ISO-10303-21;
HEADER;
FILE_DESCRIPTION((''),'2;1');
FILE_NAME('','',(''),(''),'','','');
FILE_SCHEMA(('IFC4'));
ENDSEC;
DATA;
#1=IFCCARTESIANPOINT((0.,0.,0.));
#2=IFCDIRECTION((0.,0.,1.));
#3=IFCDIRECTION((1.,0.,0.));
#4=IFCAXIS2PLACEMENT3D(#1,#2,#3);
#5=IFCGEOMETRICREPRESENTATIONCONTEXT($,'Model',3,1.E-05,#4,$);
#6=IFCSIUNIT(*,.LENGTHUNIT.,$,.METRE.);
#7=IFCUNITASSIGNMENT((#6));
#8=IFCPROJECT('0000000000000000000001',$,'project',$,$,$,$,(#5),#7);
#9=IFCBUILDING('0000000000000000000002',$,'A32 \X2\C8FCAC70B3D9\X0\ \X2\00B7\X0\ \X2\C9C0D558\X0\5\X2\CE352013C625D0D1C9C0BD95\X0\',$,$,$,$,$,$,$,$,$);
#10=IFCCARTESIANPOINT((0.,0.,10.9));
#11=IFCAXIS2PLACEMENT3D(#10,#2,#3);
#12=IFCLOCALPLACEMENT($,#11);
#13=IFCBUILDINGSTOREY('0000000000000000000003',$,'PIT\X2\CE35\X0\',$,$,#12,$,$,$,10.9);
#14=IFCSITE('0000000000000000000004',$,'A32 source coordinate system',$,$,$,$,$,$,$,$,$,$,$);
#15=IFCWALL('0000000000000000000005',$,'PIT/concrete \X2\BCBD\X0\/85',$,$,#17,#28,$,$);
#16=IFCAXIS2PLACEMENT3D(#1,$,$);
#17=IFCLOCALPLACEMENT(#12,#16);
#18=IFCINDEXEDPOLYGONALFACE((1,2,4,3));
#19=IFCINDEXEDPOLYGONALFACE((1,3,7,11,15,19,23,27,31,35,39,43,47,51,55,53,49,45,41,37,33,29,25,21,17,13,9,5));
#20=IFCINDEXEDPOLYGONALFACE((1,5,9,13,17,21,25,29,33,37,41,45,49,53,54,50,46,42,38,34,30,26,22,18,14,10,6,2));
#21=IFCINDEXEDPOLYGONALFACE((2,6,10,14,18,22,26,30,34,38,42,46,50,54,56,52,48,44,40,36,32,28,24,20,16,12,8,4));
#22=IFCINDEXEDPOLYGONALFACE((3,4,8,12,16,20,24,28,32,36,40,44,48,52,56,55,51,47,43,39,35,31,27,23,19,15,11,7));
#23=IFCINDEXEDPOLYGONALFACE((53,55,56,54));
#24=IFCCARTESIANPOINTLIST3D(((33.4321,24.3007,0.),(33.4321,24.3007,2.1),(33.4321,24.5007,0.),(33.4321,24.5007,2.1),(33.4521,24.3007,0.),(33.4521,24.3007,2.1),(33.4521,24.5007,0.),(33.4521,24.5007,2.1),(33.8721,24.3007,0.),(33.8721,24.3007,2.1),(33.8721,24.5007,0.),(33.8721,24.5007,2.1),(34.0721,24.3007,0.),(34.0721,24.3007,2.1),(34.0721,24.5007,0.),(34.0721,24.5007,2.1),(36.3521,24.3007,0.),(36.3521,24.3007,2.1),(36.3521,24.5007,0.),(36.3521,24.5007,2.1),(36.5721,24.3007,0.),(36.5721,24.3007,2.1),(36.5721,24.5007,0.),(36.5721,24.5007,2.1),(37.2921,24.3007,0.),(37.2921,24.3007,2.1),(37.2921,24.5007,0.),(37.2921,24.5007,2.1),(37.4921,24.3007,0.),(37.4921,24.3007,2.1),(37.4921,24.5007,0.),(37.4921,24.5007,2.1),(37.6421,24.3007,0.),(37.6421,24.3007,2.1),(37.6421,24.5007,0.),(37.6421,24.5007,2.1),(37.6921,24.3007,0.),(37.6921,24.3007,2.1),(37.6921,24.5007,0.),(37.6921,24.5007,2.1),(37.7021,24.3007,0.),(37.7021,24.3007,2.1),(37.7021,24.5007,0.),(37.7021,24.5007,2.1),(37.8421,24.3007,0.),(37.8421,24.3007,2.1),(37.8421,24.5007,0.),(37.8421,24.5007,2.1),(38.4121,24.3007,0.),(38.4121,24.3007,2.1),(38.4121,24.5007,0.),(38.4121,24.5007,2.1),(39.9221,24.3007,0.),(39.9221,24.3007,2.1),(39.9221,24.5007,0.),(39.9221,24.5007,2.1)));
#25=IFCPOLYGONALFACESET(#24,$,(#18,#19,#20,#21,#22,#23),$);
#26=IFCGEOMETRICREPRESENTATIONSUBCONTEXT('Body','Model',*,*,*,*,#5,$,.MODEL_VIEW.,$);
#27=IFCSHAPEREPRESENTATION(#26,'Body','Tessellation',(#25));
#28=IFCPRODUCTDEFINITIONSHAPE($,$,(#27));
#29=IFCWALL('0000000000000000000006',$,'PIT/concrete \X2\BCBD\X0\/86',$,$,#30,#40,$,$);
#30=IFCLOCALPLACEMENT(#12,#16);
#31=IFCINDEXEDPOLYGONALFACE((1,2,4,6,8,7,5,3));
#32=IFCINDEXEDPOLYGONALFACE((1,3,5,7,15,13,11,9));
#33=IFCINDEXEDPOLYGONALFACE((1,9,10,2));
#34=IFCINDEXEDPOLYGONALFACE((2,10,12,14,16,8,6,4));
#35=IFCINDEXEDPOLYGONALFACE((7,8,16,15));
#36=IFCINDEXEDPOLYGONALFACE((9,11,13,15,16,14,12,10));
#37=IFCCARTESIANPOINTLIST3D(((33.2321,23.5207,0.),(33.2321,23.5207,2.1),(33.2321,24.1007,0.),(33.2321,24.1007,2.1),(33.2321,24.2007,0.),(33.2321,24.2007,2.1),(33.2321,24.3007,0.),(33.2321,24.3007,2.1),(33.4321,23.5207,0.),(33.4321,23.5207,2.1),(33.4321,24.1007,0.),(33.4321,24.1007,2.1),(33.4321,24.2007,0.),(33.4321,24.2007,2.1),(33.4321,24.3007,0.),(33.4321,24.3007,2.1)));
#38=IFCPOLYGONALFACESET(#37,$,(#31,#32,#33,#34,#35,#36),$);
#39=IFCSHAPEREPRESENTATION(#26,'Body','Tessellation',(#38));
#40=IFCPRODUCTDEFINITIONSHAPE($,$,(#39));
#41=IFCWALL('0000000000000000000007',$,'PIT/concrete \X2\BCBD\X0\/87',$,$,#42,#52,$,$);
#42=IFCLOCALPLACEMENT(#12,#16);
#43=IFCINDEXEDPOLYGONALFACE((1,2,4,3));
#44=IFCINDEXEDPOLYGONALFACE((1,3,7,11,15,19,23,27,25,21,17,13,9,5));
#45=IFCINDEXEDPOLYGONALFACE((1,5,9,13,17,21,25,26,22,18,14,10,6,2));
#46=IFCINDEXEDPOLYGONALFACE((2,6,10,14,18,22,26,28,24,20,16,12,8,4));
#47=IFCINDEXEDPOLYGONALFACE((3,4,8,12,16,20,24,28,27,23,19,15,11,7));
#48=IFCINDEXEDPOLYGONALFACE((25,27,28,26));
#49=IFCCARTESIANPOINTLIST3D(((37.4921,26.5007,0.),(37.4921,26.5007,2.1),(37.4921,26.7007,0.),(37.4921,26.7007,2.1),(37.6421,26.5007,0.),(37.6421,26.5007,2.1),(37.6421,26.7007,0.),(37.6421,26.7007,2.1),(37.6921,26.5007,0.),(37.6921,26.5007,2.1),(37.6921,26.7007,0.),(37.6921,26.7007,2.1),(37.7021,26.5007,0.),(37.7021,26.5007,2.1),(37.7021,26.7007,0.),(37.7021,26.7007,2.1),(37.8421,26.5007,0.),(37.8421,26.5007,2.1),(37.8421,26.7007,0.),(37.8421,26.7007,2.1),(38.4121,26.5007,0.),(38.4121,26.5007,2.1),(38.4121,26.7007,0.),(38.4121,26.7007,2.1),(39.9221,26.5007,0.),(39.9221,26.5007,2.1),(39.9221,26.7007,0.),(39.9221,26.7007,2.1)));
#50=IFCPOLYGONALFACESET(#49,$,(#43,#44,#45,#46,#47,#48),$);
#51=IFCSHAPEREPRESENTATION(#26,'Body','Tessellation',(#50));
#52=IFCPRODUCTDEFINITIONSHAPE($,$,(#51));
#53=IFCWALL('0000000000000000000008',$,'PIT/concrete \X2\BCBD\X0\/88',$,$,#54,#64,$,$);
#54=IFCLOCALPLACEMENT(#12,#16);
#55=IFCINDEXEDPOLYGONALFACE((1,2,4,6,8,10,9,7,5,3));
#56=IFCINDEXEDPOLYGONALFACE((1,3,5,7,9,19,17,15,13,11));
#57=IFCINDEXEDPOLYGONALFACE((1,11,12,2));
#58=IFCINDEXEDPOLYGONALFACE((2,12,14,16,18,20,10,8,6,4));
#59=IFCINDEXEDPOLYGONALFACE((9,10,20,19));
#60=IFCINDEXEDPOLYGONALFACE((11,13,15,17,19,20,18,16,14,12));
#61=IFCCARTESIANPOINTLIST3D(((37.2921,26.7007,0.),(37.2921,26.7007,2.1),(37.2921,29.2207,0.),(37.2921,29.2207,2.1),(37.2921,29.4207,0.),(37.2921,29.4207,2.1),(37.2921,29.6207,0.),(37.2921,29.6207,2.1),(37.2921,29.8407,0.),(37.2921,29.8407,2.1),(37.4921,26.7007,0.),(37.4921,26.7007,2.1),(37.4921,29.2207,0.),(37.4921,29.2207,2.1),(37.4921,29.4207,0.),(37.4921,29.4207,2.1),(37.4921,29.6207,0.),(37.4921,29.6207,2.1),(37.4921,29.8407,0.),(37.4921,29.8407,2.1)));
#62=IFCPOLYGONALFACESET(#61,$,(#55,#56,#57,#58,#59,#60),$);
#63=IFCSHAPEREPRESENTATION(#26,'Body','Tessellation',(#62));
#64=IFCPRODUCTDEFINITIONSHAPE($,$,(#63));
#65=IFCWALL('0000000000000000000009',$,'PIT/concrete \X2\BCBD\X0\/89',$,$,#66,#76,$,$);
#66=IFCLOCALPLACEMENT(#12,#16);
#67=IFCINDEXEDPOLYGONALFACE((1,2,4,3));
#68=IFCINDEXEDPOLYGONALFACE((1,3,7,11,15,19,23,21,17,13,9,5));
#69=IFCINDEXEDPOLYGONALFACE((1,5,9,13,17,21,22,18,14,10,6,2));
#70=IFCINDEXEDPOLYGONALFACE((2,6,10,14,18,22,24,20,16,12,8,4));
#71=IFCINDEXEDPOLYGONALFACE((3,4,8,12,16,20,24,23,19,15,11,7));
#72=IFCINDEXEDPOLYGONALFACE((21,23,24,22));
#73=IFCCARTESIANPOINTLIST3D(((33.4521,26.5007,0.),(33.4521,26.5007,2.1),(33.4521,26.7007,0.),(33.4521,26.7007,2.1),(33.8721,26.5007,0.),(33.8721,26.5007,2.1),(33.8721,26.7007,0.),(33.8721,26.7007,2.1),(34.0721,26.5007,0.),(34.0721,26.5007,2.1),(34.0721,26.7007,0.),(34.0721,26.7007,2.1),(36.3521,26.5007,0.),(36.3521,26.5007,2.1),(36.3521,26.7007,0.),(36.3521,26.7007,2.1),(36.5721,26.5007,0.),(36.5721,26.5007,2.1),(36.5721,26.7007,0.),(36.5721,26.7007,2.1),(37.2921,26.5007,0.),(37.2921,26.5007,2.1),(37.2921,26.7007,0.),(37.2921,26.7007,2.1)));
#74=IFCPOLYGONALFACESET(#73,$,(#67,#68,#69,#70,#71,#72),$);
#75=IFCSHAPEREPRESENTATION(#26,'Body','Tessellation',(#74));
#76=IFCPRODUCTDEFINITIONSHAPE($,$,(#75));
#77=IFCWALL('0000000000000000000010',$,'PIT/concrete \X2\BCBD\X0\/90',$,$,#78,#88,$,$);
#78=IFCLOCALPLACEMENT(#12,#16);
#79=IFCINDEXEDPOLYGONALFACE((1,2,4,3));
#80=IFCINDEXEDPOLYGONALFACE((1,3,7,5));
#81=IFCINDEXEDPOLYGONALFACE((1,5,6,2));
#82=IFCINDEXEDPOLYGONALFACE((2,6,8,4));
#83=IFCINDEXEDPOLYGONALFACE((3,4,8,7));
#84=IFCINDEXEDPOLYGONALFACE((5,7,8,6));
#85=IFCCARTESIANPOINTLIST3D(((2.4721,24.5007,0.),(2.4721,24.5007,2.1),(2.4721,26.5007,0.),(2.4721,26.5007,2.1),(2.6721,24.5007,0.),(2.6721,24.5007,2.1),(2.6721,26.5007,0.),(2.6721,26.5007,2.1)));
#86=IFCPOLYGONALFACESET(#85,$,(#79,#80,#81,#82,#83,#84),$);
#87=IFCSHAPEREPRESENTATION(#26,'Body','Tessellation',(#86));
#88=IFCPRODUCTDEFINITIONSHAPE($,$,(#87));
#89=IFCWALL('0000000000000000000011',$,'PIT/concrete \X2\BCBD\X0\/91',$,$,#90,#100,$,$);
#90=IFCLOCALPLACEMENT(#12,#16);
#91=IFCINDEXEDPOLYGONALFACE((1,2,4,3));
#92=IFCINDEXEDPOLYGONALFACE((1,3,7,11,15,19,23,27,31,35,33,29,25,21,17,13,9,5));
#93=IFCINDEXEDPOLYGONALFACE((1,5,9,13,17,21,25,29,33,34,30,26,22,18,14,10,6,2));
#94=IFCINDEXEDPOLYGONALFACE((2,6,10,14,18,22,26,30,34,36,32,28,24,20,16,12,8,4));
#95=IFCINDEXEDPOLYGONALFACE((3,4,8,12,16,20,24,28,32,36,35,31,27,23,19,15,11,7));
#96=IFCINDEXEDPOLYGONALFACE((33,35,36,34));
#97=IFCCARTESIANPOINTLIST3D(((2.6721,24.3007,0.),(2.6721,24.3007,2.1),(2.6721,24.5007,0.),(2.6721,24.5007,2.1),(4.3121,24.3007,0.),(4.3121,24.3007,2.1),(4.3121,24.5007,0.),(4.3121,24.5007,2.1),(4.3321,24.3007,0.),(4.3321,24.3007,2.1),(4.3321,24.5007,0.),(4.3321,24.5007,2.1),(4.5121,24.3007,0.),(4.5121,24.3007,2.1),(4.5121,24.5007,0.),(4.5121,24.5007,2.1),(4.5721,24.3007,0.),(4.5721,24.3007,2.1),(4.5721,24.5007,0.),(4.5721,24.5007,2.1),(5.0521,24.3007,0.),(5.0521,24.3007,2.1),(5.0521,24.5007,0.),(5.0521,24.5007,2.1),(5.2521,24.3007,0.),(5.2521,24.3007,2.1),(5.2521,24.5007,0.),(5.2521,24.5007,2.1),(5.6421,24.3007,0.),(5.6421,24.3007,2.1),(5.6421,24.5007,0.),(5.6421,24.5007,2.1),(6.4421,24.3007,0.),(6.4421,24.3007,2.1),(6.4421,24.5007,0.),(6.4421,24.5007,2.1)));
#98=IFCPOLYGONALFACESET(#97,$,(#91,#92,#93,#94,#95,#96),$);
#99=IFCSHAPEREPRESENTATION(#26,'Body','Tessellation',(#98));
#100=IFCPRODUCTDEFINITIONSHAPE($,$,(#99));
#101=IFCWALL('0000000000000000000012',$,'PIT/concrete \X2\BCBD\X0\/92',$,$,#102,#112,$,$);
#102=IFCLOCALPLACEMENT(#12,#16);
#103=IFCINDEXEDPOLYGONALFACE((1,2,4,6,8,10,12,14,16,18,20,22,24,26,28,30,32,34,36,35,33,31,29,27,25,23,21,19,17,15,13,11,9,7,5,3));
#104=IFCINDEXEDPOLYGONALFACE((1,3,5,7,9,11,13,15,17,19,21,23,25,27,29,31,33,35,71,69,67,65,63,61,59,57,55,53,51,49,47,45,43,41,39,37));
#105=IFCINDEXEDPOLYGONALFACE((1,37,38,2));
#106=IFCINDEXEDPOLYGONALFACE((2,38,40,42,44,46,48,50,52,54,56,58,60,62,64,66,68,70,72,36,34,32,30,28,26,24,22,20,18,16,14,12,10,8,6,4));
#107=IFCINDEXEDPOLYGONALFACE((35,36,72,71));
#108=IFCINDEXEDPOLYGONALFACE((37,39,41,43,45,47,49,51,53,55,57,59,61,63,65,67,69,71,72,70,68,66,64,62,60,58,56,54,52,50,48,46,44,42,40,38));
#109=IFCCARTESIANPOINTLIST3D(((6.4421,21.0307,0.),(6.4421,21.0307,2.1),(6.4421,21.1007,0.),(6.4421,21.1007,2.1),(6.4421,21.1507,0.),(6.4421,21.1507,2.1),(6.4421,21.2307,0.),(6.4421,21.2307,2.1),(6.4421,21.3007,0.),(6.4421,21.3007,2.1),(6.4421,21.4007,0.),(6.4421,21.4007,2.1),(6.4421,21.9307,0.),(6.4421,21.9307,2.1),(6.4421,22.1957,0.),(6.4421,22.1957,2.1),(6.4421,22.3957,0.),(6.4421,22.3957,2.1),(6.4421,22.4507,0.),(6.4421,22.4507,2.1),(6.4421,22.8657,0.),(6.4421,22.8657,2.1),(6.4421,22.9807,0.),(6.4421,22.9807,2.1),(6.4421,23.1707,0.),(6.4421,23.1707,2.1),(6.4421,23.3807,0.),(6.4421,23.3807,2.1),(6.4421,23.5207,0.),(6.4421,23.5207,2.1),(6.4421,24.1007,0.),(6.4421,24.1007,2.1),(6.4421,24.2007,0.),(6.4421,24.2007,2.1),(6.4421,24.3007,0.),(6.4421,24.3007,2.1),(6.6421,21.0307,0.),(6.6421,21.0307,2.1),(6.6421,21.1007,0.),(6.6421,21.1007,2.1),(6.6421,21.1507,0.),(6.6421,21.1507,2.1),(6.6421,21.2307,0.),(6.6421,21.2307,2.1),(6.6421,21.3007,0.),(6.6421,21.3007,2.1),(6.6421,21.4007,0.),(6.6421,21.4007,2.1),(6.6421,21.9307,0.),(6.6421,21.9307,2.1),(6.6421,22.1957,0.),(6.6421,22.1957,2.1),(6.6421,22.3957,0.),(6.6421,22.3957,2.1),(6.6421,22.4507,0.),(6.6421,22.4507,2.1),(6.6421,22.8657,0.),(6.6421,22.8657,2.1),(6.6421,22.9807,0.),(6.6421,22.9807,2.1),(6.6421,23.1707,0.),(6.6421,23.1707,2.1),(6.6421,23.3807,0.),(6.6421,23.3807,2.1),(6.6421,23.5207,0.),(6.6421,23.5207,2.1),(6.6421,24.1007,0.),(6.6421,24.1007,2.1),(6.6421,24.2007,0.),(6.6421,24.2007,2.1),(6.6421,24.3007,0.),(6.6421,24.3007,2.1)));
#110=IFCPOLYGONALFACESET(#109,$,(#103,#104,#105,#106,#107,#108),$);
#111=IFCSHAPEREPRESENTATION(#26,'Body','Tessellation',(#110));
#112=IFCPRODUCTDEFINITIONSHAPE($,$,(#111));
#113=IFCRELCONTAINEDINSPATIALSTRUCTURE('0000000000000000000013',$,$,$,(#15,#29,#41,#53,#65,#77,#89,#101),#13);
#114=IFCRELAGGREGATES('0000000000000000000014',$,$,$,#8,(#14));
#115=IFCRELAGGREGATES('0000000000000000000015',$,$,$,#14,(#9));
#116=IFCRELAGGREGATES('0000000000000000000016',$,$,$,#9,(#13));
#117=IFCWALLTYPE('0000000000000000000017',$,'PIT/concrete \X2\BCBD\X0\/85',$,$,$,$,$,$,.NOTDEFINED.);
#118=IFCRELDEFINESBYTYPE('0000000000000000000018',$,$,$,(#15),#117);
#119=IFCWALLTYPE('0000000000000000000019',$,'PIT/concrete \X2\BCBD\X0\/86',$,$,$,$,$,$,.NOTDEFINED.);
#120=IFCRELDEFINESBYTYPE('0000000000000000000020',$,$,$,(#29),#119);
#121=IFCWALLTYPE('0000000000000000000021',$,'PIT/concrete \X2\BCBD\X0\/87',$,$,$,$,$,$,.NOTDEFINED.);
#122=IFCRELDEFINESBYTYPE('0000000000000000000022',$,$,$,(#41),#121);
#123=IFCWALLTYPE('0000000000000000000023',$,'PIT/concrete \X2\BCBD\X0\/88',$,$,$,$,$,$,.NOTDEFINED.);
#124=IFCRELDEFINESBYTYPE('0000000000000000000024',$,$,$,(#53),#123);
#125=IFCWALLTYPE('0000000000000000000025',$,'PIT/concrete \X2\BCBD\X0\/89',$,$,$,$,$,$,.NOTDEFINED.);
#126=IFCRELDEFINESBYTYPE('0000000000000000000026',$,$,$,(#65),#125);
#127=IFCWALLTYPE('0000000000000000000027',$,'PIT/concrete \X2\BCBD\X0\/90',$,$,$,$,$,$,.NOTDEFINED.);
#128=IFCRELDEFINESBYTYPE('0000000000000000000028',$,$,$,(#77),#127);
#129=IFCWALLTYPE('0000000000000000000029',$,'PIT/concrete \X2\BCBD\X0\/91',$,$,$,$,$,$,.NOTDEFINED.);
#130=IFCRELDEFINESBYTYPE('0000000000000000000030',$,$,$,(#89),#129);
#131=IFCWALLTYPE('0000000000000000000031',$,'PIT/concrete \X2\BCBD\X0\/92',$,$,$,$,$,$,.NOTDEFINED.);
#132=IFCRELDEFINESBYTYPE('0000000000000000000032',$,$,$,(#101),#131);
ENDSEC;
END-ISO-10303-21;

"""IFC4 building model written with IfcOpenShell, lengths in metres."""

from ifc_helpers import new_model, si_unit, frame, origin, origin_with_axes, place, context, subcontext, project, spatial, polyline, outline, extrude, source, transform, mapped, type_object, type_shapes, element, save


model = new_model("IFC4")

# Units and contexts
model_context = context("Model", 3, precision=1e-05, world=origin_with_axes())
body_context = subcontext(model_context, "Body", "Model", "MODEL_VIEW")
ifc_project = project(units=[si_unit("LENGTHUNIT", "METRE")], contexts=[model_context])

# Site, building, storey
site = spatial("IfcSite", under=ifc_project, Name="A32 source coordinate system")
building = spatial("IfcBuilding", under=site, Name="A32 주거동 · 지하5층–옥탑지붕")
storey_placement = place(None, frame((0.0, 0.0, 10.9), z_axis=(0.0, 0.0, 1.0), x_axis=(1.0, 0.0, 0.0)))
storey = spatial("IfcBuildingStorey", under=building, at=storey_placement, Name="PIT층", Elevation=10.9)

# Walls
wall_type_1 = type_object("IfcWallType", Name="PIT/concrete 벽/85", PredefinedType="NOTDEFINED")
shared_shape_1 = source(origin(), body_context, "Body", "SweptSolid", [
    extrude(outline(polyline([(37.8421, 24.3007), (37.7021, 24.3007), (37.6921, 24.3007), (37.6421, 24.3007), (37.4921, 24.3007), (37.2921, 24.3007), (36.5721, 24.3007), (36.3521, 24.3007), (34.0721, 24.3007), (33.8721, 24.3007), (33.4521, 24.3007), (33.4321, 24.3007), (33.4321, 24.5007), (33.4521, 24.5007), (33.8721, 24.5007), (34.0721, 24.5007), (36.3521, 24.5007), (36.5721, 24.5007), (37.2921, 24.5007), (37.4921, 24.5007), (37.6421, 24.5007), (37.6921, 24.5007), (37.7021, 24.5007), (37.8421, 24.5007), (38.4121, 24.5007), (39.9221, 24.5007), (39.9221, 24.3007), (38.4121, 24.3007), (37.8421, 24.3007)])), origin(), (0.0, 0.0, 1.0), 2.1),
])
type_shapes(wall_type_1, [shared_shape_1])
wall_1_placement = place(storey_placement, origin_with_axes())
element("IfcWall", 1, at=wall_1_placement, inside=storey, type_object=wall_type_1, Name="PIT/concrete 벽/85", context=body_context, shape_type="MappedRepresentation", body=[
    mapped(shared_shape_1, transform((0.0, 0.0, 0.0), scale=1.0)),
])
wall_type_2 = type_object("IfcWallType", Name="PIT/concrete 벽/86", PredefinedType="NOTDEFINED")
shared_shape_2 = source(origin(), body_context, "Body", "SweptSolid", [
    extrude(outline(polyline([(33.4321, 23.5207), (33.2321, 23.5207), (33.2321, 24.1007), (33.2321, 24.2007), (33.2321, 24.3007), (33.4321, 24.3007), (33.4321, 24.2007), (33.4321, 24.1007), (33.4321, 23.5207)])), origin(), (0.0, 0.0, 1.0), 2.1),
])
type_shapes(wall_type_2, [shared_shape_2])
wall_2_placement = place(storey_placement, origin_with_axes())
element("IfcWall", 2, at=wall_2_placement, inside=storey, type_object=wall_type_2, Name="PIT/concrete 벽/86", context=body_context, shape_type="MappedRepresentation", body=[
    mapped(shared_shape_2, transform((0.0, 0.0, 0.0), scale=1.0)),
])
wall_type_3 = type_object("IfcWallType", Name="PIT/concrete 벽/87", PredefinedType="NOTDEFINED")
shared_shape_3 = source(origin(), body_context, "Body", "SweptSolid", [
    extrude(outline(polyline([(37.7021, 26.5007), (37.6921, 26.5007), (37.6421, 26.5007), (37.4921, 26.5007), (37.4921, 26.7007), (37.6421, 26.7007), (37.6921, 26.7007), (37.7021, 26.7007), (37.8421, 26.7007), (38.4121, 26.7007), (39.9221, 26.7007), (39.9221, 26.5007), (38.4121, 26.5007), (37.8421, 26.5007), (37.7021, 26.5007)])), origin(), (0.0, 0.0, 1.0), 2.1),
])
type_shapes(wall_type_3, [shared_shape_3])
wall_3_placement = place(storey_placement, origin_with_axes())
element("IfcWall", 3, at=wall_3_placement, inside=storey, type_object=wall_type_3, Name="PIT/concrete 벽/87", context=body_context, shape_type="MappedRepresentation", body=[
    mapped(shared_shape_3, transform((0.0, 0.0, 0.0), scale=1.0)),
])
wall_type_4 = type_object("IfcWallType", Name="PIT/concrete 벽/88", PredefinedType="NOTDEFINED")
shared_shape_4 = source(origin(), body_context, "Body", "SweptSolid", [
    extrude(outline(polyline([(37.2921, 29.4207), (37.2921, 29.6207), (37.2921, 29.8407), (37.4921, 29.8407), (37.4921, 29.6207), (37.4921, 29.4207), (37.4921, 29.2207), (37.4921, 26.7007), (37.2921, 26.7007), (37.2921, 29.2207), (37.2921, 29.4207)])), origin(), (0.0, 0.0, 1.0), 2.1),
])
type_shapes(wall_type_4, [shared_shape_4])
wall_4_placement = place(storey_placement, origin_with_axes())
element("IfcWall", 4, at=wall_4_placement, inside=storey, type_object=wall_type_4, Name="PIT/concrete 벽/88", context=body_context, shape_type="MappedRepresentation", body=[
    mapped(shared_shape_4, transform((0.0, 0.0, 0.0), scale=1.0)),
])
wall_type_5 = type_object("IfcWallType", Name="PIT/concrete 벽/89", PredefinedType="NOTDEFINED")
shared_shape_5 = source(origin(), body_context, "Body", "SweptSolid", [
    extrude(outline(polyline([(36.3521, 26.5007), (34.0721, 26.5007), (33.8721, 26.5007), (33.4521, 26.5007), (33.4521, 26.7007), (33.8721, 26.7007), (34.0721, 26.7007), (36.3521, 26.7007), (36.5721, 26.7007), (37.2921, 26.7007), (37.2921, 26.5007), (36.5721, 26.5007), (36.3521, 26.5007)])), origin(), (0.0, 0.0, 1.0), 2.1),
])
type_shapes(wall_type_5, [shared_shape_5])
wall_5_placement = place(storey_placement, origin_with_axes())
element("IfcWall", 5, at=wall_5_placement, inside=storey, type_object=wall_type_5, Name="PIT/concrete 벽/89", context=body_context, shape_type="MappedRepresentation", body=[
    mapped(shared_shape_5, transform((0.0, 0.0, 0.0), scale=1.0)),
])
wall_type_6 = type_object("IfcWallType", Name="PIT/concrete 벽/90", PredefinedType="NOTDEFINED")
shared_shape_6 = source(origin(), body_context, "Body", "SweptSolid", [
    extrude(outline(polyline([(2.4721, 24.5007), (2.4721, 26.5007), (2.6721, 26.5007), (2.6721, 24.5007), (2.4721, 24.5007)])), origin(), (0.0, 0.0, 1.0), 2.1),
])
type_shapes(wall_type_6, [shared_shape_6])
wall_6_placement = place(storey_placement, origin_with_axes())
element("IfcWall", 6, at=wall_6_placement, inside=storey, type_object=wall_type_6, Name="PIT/concrete 벽/90", context=body_context, shape_type="MappedRepresentation", body=[
    mapped(shared_shape_6, transform((0.0, 0.0, 0.0), scale=1.0)),
])
wall_type_7 = type_object("IfcWallType", Name="PIT/concrete 벽/91", PredefinedType="NOTDEFINED")
shared_shape_7 = source(origin(), body_context, "Body", "SweptSolid", [
    extrude(outline(polyline([(4.5121, 24.5007), (4.5721, 24.5007), (5.0521, 24.5007), (5.2521, 24.5007), (5.6421, 24.5007), (6.4421, 24.5007), (6.4421, 24.3007), (5.6421, 24.3007), (5.2521, 24.3007), (5.0521, 24.3007), (4.5721, 24.3007), (4.5121, 24.3007), (4.3321, 24.3007), (4.3121, 24.3007), (2.6721, 24.3007), (2.6721, 24.5007), (4.3121, 24.5007), (4.3321, 24.5007), (4.5121, 24.5007)])), origin(), (0.0, 0.0, 1.0), 2.1),
])
type_shapes(wall_type_7, [shared_shape_7])
wall_7_placement = place(storey_placement, origin_with_axes())
element("IfcWall", 7, at=wall_7_placement, inside=storey, type_object=wall_type_7, Name="PIT/concrete 벽/91", context=body_context, shape_type="MappedRepresentation", body=[
    mapped(shared_shape_7, transform((0.0, 0.0, 0.0), scale=1.0)),
])
wall_type_8 = type_object("IfcWallType", Name="PIT/concrete 벽/92", PredefinedType="NOTDEFINED")
shared_shape_8 = source(origin(), body_context, "Body", "SweptSolid", [
    extrude(outline(polyline([(6.6421, 24.1007), (6.6421, 23.5207), (6.6421, 23.3807), (6.6421, 23.1707), (6.6421, 22.9807), (6.6421, 22.8657), (6.6421, 22.4507), (6.6421, 22.3957), (6.6421, 22.1957), (6.6421, 21.9307), (6.6421, 21.4007), (6.6421, 21.3007), (6.6421, 21.2307), (6.6421, 21.1507), (6.6421, 21.1007), (6.6421, 21.0307), (6.4421, 21.0307), (6.4421, 21.1007), (6.4421, 21.1507), (6.4421, 21.2307), (6.4421, 21.3007), (6.4421, 21.4007), (6.4421, 21.9307), (6.4421, 22.1957), (6.4421, 22.3957), (6.4421, 22.4507), (6.4421, 22.8657), (6.4421, 22.9807), (6.4421, 23.1707), (6.4421, 23.3807), (6.4421, 23.5207), (6.4421, 24.1007), (6.4421, 24.2007), (6.4421, 24.3007), (6.6421, 24.3007), (6.6421, 24.2007), (6.6421, 24.1007)])), origin(), (0.0, 0.0, 1.0), 2.1),
])
type_shapes(wall_type_8, [shared_shape_8])
wall_8_placement = place(storey_placement, origin_with_axes())
element("IfcWall", 8, at=wall_8_placement, inside=storey, type_object=wall_type_8, Name="PIT/concrete 벽/92", context=body_context, shape_type="MappedRepresentation", body=[
    mapped(shared_shape_8, transform((0.0, 0.0, 0.0), scale=1.0)),
])

save(model, "model.ifc")
